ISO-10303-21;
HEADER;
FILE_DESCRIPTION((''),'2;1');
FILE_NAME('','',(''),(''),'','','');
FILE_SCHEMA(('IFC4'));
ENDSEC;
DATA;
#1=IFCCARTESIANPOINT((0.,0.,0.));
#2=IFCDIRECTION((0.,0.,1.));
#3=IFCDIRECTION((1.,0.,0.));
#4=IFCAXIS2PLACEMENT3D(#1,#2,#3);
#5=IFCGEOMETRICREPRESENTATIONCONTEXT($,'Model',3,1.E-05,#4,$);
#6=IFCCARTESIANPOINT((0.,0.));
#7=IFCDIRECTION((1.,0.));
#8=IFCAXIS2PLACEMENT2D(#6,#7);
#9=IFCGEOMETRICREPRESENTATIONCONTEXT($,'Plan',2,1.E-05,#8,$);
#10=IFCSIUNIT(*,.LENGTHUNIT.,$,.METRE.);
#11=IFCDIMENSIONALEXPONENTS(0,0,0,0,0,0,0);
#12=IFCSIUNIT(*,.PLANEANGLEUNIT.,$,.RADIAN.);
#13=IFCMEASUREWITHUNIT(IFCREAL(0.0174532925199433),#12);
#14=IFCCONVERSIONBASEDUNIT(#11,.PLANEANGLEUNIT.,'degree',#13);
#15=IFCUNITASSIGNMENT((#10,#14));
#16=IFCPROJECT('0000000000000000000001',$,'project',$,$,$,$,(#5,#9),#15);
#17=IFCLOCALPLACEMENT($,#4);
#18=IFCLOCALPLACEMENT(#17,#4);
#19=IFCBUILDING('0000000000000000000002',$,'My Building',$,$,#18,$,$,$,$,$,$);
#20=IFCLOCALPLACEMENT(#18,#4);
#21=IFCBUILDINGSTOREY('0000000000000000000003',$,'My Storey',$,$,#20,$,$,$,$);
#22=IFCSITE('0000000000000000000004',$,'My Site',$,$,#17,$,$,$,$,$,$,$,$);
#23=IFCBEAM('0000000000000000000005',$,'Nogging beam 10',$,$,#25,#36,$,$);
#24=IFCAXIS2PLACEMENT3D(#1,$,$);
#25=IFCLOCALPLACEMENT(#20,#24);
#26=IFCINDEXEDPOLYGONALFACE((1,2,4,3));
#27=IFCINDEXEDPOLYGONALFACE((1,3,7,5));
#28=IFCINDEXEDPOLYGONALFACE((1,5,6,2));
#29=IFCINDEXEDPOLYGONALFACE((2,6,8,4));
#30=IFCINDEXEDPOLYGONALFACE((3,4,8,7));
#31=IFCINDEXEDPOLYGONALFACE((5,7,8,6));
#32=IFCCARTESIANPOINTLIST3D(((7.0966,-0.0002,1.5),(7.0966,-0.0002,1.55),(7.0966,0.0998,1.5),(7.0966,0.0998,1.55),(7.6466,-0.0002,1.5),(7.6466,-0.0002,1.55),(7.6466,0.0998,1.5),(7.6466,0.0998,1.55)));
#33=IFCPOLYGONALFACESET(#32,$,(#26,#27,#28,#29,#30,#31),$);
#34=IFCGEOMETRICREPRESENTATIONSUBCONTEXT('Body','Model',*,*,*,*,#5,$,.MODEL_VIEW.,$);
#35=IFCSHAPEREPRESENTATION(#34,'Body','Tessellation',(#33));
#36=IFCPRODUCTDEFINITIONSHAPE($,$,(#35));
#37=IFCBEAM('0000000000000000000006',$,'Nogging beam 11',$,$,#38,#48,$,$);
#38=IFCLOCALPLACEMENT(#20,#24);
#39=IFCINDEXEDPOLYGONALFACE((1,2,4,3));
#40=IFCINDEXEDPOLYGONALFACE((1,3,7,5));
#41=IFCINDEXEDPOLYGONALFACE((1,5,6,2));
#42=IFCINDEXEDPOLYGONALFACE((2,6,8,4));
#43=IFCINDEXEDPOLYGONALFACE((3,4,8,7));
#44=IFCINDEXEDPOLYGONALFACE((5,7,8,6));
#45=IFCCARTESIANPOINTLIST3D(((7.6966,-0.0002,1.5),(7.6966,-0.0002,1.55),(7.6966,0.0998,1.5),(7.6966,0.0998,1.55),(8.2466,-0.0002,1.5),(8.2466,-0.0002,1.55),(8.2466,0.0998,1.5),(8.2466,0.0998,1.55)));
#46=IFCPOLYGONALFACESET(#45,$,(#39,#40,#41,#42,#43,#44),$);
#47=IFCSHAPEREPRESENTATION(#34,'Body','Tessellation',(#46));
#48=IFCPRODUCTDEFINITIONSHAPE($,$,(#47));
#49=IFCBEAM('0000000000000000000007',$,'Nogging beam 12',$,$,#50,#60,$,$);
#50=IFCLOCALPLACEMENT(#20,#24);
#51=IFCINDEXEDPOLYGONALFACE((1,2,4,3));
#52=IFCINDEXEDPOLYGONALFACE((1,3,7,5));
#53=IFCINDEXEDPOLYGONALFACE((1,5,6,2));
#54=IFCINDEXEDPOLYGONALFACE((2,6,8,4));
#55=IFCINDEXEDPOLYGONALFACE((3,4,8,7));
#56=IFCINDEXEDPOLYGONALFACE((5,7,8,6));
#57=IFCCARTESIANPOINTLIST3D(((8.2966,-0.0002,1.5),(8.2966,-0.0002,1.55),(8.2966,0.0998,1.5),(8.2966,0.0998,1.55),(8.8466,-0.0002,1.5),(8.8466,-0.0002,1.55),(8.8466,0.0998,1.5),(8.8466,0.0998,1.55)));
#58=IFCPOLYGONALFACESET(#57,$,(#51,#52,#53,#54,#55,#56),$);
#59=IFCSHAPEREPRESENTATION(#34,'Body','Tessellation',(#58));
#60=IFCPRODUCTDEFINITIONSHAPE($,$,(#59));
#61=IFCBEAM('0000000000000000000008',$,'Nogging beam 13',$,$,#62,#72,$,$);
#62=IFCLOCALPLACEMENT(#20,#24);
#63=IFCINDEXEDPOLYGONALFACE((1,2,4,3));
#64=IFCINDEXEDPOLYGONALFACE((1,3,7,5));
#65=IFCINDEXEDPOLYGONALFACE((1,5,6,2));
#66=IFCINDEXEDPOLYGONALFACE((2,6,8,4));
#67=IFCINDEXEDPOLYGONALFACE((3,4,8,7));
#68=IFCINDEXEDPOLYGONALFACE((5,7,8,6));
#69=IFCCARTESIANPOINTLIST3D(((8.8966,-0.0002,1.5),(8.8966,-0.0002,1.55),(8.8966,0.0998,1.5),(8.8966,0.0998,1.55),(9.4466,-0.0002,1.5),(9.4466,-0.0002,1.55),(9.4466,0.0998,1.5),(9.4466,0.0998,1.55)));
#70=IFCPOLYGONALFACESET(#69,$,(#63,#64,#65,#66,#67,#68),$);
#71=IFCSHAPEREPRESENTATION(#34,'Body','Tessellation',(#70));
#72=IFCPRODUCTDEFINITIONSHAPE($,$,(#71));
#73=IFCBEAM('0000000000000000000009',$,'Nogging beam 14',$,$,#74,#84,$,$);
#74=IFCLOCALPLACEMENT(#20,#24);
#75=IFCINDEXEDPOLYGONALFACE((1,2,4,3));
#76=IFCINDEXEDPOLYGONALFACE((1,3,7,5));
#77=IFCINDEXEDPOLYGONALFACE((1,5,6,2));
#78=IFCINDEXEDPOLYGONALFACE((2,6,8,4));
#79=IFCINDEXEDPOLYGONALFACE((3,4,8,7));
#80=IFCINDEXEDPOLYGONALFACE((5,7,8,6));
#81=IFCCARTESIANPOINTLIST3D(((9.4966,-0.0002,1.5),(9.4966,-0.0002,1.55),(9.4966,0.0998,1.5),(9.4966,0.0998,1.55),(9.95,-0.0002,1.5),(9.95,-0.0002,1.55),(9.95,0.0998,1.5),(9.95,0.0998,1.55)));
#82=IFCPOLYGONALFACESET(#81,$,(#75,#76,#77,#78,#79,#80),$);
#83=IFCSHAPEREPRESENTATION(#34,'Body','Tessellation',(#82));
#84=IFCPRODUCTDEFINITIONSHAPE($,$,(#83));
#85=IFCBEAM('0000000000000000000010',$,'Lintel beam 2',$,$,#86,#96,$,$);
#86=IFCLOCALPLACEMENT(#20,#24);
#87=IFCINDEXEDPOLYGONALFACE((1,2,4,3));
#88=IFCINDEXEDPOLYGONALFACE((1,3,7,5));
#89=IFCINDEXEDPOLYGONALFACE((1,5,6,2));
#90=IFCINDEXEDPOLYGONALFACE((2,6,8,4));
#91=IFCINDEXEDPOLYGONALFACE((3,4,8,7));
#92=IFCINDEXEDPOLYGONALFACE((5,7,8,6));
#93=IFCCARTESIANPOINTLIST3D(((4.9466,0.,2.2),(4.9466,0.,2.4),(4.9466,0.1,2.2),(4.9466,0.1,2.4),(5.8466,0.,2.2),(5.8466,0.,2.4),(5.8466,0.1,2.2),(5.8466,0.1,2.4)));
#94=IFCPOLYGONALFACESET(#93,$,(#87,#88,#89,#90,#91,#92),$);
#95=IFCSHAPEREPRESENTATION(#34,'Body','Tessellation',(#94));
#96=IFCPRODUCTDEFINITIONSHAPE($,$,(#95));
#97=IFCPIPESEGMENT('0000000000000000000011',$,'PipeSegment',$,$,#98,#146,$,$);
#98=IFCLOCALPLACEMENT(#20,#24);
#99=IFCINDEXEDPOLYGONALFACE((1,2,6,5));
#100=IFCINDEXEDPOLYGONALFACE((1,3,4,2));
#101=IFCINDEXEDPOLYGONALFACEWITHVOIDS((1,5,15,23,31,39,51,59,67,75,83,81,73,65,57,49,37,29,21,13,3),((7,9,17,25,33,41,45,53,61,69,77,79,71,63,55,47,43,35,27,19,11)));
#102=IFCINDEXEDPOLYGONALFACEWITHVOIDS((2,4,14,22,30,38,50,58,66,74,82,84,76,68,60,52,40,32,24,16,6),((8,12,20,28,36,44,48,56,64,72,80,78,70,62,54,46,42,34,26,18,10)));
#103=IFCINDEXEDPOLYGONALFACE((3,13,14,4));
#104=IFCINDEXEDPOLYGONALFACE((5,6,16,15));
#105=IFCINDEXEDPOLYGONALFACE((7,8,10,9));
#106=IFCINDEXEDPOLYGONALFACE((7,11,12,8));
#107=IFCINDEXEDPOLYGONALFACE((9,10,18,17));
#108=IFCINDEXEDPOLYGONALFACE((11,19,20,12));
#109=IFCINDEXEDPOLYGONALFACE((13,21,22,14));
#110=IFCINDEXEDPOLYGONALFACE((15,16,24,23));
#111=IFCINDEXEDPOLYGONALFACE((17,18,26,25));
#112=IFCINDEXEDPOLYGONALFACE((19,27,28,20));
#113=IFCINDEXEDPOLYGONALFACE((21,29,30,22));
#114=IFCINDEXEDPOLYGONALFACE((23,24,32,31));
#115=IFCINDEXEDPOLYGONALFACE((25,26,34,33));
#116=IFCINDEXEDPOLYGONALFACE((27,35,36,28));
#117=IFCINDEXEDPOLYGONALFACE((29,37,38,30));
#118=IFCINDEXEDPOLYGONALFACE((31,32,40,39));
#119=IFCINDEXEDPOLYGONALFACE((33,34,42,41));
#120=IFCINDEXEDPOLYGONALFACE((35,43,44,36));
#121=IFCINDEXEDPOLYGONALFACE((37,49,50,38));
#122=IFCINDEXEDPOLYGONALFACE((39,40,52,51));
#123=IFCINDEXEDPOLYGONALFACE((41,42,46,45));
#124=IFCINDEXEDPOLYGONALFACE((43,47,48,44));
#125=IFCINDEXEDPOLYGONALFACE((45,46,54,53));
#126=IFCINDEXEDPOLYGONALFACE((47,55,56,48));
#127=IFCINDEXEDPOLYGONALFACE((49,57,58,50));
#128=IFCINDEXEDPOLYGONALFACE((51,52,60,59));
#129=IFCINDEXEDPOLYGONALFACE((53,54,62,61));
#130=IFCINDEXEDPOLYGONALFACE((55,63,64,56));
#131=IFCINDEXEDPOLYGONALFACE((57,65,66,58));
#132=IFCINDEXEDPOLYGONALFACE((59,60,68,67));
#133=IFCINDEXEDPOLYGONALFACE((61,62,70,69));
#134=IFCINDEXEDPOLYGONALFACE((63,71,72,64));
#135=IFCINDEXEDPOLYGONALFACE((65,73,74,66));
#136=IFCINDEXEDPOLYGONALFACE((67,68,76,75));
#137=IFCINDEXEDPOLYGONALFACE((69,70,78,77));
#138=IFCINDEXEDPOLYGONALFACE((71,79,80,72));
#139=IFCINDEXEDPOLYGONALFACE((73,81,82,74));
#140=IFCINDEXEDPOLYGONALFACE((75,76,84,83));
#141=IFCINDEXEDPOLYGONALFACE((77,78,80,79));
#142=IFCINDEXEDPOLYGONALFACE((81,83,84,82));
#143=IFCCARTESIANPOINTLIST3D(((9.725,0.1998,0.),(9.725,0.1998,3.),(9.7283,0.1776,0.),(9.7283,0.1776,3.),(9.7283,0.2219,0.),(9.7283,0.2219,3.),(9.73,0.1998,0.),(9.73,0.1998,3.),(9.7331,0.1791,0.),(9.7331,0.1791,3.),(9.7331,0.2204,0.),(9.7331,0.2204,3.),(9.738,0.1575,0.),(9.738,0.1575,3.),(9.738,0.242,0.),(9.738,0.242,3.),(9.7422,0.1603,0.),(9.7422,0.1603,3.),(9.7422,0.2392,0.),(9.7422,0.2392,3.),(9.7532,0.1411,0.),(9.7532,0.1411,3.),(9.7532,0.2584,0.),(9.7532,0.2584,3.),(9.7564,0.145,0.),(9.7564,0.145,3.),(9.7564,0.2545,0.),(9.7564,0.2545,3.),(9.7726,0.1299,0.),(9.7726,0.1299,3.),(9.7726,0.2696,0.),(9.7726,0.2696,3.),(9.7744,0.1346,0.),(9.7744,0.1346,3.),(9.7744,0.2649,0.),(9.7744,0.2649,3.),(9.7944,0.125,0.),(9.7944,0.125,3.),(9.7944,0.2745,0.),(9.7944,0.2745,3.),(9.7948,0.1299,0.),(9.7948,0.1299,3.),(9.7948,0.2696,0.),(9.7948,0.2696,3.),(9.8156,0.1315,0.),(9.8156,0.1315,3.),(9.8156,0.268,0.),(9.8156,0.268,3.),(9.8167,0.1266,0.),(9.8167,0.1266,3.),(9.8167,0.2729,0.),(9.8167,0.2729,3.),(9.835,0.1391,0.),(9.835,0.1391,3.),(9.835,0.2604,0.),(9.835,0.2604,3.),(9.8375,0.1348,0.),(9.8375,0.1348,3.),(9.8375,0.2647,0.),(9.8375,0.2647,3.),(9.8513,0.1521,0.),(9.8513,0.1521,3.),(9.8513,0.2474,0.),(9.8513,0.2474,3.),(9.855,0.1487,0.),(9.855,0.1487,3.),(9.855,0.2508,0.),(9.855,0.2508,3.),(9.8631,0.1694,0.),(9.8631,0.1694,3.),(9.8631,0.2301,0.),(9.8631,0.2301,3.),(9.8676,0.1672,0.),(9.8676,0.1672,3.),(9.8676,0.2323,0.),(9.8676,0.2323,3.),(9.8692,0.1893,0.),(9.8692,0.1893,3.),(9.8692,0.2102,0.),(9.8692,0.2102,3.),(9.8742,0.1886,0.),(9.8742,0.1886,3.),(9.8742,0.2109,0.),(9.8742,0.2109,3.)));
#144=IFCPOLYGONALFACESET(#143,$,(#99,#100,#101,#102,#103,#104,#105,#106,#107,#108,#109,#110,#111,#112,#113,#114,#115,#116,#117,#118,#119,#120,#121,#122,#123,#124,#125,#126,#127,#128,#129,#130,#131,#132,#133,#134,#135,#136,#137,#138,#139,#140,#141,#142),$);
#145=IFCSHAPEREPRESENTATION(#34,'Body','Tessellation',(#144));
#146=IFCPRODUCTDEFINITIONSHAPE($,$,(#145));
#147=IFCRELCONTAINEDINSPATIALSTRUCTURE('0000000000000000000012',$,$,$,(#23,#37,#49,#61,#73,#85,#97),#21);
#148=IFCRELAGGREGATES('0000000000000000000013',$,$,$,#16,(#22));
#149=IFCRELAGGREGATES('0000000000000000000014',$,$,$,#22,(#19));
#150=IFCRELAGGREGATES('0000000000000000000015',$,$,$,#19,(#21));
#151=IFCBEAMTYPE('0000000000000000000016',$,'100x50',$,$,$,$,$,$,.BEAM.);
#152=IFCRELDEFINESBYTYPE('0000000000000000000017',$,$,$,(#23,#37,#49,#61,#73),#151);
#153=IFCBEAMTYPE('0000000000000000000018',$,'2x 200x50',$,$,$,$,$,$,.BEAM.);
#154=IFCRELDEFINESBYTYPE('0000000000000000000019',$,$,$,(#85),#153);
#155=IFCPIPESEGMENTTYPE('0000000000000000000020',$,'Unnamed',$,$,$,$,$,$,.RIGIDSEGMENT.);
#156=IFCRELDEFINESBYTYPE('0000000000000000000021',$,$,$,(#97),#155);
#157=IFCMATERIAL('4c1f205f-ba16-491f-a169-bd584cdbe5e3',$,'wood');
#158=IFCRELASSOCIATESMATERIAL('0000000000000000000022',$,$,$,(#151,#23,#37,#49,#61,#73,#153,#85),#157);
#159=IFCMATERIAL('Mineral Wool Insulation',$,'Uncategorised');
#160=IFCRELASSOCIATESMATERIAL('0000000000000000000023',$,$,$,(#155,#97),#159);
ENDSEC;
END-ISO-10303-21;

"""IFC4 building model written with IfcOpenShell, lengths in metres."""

from ifc_helpers import new_model, entity, si_unit, converted_unit, frame, origin_with_axes, origin_2d_with_axis, place, context, subcontext, project, spatial, indexed_curve, hollow_circle, outline, extrude, material, material_profile, profile_set, profile_usage, type_object, element, save


model = new_model("IFC4")

# Units and contexts
model_context = context("Model", 3, precision=1e-05, world=origin_with_axes())
plan_context = context("Plan", 2, precision=1e-05, world=origin_2d_with_axis())
body_context = subcontext(model_context, "Body", "Model", "MODEL_VIEW")
ifc_project = project(units=[si_unit("LENGTHUNIT", "METRE"), converted_unit("PLANEANGLEUNIT", "degree", entity("IfcReal", 0.0174532925199433), si_unit("PLANEANGLEUNIT", "RADIAN"), dimensions=[0, 0, 0, 0, 0, 0, 0])], contexts=[model_context, plan_context])

# Site, building, storey
site_placement = place(None, origin_with_axes())
site = spatial("IfcSite", under=ifc_project, at=site_placement, Name="My Site")
building_placement = place(site_placement, origin_with_axes())
building = spatial("IfcBuilding", under=site, at=building_placement, Name="My Building")
storey_placement = place(building_placement, origin_with_axes())
storey = spatial("IfcBuildingStorey", under=building, at=storey_placement, Name="My Storey")

# Shared definitions
ifc_material_1 = material(Name="4c1f205f-ba16-491f-a169-bd584cdbe5e3", Category="wood")

# Beams
ifc_material_profile_1 = material_profile(ifc_material_1, outline(indexed_curve([(-0.05, 0.025), (0.05, 0.025), (0.05, -0.025), (-0.05, -0.025), (-0.05, 0.025)])))
ifc_profile_set_1 = profile_set([ifc_material_profile_1])
beam_type_1 = type_object("IfcBeamType", Name="100x50", PredefinedType="BEAM", material=ifc_profile_set_1)
ifc_profile_usage_1 = profile_usage(ifc_profile_set_1, cardinal=5)
beam_1_placement = place(storey_placement, frame((7.0966, 0.0498, 1.525), z_axis=(1.0, -0.000001, 0.000001), x_axis=(0.000001, 1.0, 0.0)))
element("IfcBeam", 1, at=beam_1_placement, inside=storey, type_object=beam_type_1, material=ifc_profile_usage_1, Name="Nogging beam 10", context=body_context, shape_type="SweptSolid", body=[
    extrude(outline(indexed_curve([(-0.05, 0.025), (0.05, 0.025), (0.05, -0.025), (-0.05, -0.025), (-0.05, 0.025)])), origin_with_axes(), (0.0, 0.0, 1.0), 0.55),
])
ifc_profile_usage_2 = profile_usage(ifc_profile_set_1, cardinal=5)
beam_2_placement = place(storey_placement, frame((7.6966, 0.0498, 1.525), z_axis=(1.0, -0.000001, 0.000001), x_axis=(0.000001, 1.0, 0.0)))
element("IfcBeam", 2, at=beam_2_placement, inside=storey, type_object=beam_type_1, material=ifc_profile_usage_2, Name="Nogging beam 11", context=body_context, shape_type="SweptSolid", body=[
    extrude(outline(indexed_curve([(-0.05, 0.025), (0.05, 0.025), (0.05, -0.025), (-0.05, -0.025), (-0.05, 0.025)])), origin_with_axes(), (0.0, 0.0, 1.0), 0.55),
])
ifc_profile_usage_3 = profile_usage(ifc_profile_set_1, cardinal=5)
beam_3_placement = place(storey_placement, frame((8.2966, 0.0498, 1.525), z_axis=(1.0, -0.000001, 0.000001), x_axis=(0.000001, 1.0, 0.0)))
element("IfcBeam", 3, at=beam_3_placement, inside=storey, type_object=beam_type_1, material=ifc_profile_usage_3, Name="Nogging beam 12", context=body_context, shape_type="SweptSolid", body=[
    extrude(outline(indexed_curve([(-0.05, 0.025), (0.05, 0.025), (0.05, -0.025), (-0.05, -0.025), (-0.05, 0.025)])), origin_with_axes(), (0.0, 0.0, 1.0), 0.55),
])
ifc_profile_usage_4 = profile_usage(ifc_profile_set_1, cardinal=5)
beam_4_placement = place(storey_placement, frame((8.8966, 0.0498, 1.525), z_axis=(1.0, -0.000001, 0.000001), x_axis=(0.000001, 1.0, 0.0)))
element("IfcBeam", 4, at=beam_4_placement, inside=storey, type_object=beam_type_1, material=ifc_profile_usage_4, Name="Nogging beam 13", context=body_context, shape_type="SweptSolid", body=[
    extrude(outline(indexed_curve([(-0.05, 0.025), (0.05, 0.025), (0.05, -0.025), (-0.05, -0.025), (-0.05, 0.025)])), origin_with_axes(), (0.0, 0.0, 1.0), 0.55),
])
ifc_profile_usage_5 = profile_usage(ifc_profile_set_1, cardinal=5)
beam_5_placement = place(storey_placement, frame((9.4966, 0.0498, 1.525), z_axis=(1.0, -0.000001, 0.000001), x_axis=(0.000001, 1.0, 0.0)))
element("IfcBeam", 5, at=beam_5_placement, inside=storey, type_object=beam_type_1, material=ifc_profile_usage_5, Name="Nogging beam 14", context=body_context, shape_type="SweptSolid", body=[
    extrude(outline(indexed_curve([(-0.05, 0.025), (0.05, 0.025), (0.05, -0.025), (-0.05, -0.025), (-0.05, 0.025)])), origin_with_axes(), (0.0, 0.0, 1.0), 0.4534),
])
ifc_material_profile_2 = material_profile(ifc_material_1, outline(indexed_curve([(-0.1, 0.05), (0.1, 0.05), (0.1, -0.05), (-0.1, -0.05), (-0.1, 0.05)])))
ifc_profile_set_2 = profile_set([ifc_material_profile_2])
ifc_profile_usage_6 = profile_usage(ifc_profile_set_2, cardinal=5)
beam_type_2 = type_object("IfcBeamType", Name="2x 200x50", PredefinedType="BEAM", material=ifc_profile_set_2)
beam_6_placement = place(storey_placement, frame((4.9466, 0.05, 2.3), z_axis=(1.0, 0.0, 0.0), x_axis=(0.0, 0.0, 1.0)))
element("IfcBeam", 6, at=beam_6_placement, inside=storey, type_object=beam_type_2, material=ifc_profile_usage_6, Name="Lintel beam 2", context=body_context, shape_type="SweptSolid", body=[
    extrude(outline(indexed_curve([(-0.1, 0.05), (0.1, 0.05), (0.1, -0.05), (-0.1, -0.05), (-0.1, 0.05)])), origin_with_axes(), (0.0, 0.0, 1.0), 0.9),
])

# Pipe segment
ifc_material_2 = material(Name="Mineral Wool Insulation", Category="Uncategorised")
ifc_material_profile_3 = material_profile(ifc_material_2, hollow_circle(Radius=0.075, WallThickness=0.005))
ifc_profile_set_3 = profile_set([ifc_material_profile_3])
ifc_profile_usage_7 = profile_usage(ifc_profile_set_3, cardinal=5)
pipe_segment_type = type_object("IfcPipeSegmentType", Name="Unnamed", PredefinedType="RIGIDSEGMENT", material=ifc_profile_set_3)
pipe_segment_placement = place(storey_placement, frame((9.8, 0.1998, 0.0), z_axis=(0.0, 0.0, 1.0), x_axis=(-1.0, 0.0, 0.0)))
element("IfcPipeSegment", 7, at=pipe_segment_placement, inside=storey, type_object=pipe_segment_type, material=ifc_profile_usage_7, Name="PipeSegment", context=body_context, shape_type="SweptSolid", body=[
    extrude(hollow_circle(Radius=0.075, WallThickness=0.005), origin_with_axes(), (0.0, 0.0, 1.0), 3.0),
])

save(model, "model.ifc")
